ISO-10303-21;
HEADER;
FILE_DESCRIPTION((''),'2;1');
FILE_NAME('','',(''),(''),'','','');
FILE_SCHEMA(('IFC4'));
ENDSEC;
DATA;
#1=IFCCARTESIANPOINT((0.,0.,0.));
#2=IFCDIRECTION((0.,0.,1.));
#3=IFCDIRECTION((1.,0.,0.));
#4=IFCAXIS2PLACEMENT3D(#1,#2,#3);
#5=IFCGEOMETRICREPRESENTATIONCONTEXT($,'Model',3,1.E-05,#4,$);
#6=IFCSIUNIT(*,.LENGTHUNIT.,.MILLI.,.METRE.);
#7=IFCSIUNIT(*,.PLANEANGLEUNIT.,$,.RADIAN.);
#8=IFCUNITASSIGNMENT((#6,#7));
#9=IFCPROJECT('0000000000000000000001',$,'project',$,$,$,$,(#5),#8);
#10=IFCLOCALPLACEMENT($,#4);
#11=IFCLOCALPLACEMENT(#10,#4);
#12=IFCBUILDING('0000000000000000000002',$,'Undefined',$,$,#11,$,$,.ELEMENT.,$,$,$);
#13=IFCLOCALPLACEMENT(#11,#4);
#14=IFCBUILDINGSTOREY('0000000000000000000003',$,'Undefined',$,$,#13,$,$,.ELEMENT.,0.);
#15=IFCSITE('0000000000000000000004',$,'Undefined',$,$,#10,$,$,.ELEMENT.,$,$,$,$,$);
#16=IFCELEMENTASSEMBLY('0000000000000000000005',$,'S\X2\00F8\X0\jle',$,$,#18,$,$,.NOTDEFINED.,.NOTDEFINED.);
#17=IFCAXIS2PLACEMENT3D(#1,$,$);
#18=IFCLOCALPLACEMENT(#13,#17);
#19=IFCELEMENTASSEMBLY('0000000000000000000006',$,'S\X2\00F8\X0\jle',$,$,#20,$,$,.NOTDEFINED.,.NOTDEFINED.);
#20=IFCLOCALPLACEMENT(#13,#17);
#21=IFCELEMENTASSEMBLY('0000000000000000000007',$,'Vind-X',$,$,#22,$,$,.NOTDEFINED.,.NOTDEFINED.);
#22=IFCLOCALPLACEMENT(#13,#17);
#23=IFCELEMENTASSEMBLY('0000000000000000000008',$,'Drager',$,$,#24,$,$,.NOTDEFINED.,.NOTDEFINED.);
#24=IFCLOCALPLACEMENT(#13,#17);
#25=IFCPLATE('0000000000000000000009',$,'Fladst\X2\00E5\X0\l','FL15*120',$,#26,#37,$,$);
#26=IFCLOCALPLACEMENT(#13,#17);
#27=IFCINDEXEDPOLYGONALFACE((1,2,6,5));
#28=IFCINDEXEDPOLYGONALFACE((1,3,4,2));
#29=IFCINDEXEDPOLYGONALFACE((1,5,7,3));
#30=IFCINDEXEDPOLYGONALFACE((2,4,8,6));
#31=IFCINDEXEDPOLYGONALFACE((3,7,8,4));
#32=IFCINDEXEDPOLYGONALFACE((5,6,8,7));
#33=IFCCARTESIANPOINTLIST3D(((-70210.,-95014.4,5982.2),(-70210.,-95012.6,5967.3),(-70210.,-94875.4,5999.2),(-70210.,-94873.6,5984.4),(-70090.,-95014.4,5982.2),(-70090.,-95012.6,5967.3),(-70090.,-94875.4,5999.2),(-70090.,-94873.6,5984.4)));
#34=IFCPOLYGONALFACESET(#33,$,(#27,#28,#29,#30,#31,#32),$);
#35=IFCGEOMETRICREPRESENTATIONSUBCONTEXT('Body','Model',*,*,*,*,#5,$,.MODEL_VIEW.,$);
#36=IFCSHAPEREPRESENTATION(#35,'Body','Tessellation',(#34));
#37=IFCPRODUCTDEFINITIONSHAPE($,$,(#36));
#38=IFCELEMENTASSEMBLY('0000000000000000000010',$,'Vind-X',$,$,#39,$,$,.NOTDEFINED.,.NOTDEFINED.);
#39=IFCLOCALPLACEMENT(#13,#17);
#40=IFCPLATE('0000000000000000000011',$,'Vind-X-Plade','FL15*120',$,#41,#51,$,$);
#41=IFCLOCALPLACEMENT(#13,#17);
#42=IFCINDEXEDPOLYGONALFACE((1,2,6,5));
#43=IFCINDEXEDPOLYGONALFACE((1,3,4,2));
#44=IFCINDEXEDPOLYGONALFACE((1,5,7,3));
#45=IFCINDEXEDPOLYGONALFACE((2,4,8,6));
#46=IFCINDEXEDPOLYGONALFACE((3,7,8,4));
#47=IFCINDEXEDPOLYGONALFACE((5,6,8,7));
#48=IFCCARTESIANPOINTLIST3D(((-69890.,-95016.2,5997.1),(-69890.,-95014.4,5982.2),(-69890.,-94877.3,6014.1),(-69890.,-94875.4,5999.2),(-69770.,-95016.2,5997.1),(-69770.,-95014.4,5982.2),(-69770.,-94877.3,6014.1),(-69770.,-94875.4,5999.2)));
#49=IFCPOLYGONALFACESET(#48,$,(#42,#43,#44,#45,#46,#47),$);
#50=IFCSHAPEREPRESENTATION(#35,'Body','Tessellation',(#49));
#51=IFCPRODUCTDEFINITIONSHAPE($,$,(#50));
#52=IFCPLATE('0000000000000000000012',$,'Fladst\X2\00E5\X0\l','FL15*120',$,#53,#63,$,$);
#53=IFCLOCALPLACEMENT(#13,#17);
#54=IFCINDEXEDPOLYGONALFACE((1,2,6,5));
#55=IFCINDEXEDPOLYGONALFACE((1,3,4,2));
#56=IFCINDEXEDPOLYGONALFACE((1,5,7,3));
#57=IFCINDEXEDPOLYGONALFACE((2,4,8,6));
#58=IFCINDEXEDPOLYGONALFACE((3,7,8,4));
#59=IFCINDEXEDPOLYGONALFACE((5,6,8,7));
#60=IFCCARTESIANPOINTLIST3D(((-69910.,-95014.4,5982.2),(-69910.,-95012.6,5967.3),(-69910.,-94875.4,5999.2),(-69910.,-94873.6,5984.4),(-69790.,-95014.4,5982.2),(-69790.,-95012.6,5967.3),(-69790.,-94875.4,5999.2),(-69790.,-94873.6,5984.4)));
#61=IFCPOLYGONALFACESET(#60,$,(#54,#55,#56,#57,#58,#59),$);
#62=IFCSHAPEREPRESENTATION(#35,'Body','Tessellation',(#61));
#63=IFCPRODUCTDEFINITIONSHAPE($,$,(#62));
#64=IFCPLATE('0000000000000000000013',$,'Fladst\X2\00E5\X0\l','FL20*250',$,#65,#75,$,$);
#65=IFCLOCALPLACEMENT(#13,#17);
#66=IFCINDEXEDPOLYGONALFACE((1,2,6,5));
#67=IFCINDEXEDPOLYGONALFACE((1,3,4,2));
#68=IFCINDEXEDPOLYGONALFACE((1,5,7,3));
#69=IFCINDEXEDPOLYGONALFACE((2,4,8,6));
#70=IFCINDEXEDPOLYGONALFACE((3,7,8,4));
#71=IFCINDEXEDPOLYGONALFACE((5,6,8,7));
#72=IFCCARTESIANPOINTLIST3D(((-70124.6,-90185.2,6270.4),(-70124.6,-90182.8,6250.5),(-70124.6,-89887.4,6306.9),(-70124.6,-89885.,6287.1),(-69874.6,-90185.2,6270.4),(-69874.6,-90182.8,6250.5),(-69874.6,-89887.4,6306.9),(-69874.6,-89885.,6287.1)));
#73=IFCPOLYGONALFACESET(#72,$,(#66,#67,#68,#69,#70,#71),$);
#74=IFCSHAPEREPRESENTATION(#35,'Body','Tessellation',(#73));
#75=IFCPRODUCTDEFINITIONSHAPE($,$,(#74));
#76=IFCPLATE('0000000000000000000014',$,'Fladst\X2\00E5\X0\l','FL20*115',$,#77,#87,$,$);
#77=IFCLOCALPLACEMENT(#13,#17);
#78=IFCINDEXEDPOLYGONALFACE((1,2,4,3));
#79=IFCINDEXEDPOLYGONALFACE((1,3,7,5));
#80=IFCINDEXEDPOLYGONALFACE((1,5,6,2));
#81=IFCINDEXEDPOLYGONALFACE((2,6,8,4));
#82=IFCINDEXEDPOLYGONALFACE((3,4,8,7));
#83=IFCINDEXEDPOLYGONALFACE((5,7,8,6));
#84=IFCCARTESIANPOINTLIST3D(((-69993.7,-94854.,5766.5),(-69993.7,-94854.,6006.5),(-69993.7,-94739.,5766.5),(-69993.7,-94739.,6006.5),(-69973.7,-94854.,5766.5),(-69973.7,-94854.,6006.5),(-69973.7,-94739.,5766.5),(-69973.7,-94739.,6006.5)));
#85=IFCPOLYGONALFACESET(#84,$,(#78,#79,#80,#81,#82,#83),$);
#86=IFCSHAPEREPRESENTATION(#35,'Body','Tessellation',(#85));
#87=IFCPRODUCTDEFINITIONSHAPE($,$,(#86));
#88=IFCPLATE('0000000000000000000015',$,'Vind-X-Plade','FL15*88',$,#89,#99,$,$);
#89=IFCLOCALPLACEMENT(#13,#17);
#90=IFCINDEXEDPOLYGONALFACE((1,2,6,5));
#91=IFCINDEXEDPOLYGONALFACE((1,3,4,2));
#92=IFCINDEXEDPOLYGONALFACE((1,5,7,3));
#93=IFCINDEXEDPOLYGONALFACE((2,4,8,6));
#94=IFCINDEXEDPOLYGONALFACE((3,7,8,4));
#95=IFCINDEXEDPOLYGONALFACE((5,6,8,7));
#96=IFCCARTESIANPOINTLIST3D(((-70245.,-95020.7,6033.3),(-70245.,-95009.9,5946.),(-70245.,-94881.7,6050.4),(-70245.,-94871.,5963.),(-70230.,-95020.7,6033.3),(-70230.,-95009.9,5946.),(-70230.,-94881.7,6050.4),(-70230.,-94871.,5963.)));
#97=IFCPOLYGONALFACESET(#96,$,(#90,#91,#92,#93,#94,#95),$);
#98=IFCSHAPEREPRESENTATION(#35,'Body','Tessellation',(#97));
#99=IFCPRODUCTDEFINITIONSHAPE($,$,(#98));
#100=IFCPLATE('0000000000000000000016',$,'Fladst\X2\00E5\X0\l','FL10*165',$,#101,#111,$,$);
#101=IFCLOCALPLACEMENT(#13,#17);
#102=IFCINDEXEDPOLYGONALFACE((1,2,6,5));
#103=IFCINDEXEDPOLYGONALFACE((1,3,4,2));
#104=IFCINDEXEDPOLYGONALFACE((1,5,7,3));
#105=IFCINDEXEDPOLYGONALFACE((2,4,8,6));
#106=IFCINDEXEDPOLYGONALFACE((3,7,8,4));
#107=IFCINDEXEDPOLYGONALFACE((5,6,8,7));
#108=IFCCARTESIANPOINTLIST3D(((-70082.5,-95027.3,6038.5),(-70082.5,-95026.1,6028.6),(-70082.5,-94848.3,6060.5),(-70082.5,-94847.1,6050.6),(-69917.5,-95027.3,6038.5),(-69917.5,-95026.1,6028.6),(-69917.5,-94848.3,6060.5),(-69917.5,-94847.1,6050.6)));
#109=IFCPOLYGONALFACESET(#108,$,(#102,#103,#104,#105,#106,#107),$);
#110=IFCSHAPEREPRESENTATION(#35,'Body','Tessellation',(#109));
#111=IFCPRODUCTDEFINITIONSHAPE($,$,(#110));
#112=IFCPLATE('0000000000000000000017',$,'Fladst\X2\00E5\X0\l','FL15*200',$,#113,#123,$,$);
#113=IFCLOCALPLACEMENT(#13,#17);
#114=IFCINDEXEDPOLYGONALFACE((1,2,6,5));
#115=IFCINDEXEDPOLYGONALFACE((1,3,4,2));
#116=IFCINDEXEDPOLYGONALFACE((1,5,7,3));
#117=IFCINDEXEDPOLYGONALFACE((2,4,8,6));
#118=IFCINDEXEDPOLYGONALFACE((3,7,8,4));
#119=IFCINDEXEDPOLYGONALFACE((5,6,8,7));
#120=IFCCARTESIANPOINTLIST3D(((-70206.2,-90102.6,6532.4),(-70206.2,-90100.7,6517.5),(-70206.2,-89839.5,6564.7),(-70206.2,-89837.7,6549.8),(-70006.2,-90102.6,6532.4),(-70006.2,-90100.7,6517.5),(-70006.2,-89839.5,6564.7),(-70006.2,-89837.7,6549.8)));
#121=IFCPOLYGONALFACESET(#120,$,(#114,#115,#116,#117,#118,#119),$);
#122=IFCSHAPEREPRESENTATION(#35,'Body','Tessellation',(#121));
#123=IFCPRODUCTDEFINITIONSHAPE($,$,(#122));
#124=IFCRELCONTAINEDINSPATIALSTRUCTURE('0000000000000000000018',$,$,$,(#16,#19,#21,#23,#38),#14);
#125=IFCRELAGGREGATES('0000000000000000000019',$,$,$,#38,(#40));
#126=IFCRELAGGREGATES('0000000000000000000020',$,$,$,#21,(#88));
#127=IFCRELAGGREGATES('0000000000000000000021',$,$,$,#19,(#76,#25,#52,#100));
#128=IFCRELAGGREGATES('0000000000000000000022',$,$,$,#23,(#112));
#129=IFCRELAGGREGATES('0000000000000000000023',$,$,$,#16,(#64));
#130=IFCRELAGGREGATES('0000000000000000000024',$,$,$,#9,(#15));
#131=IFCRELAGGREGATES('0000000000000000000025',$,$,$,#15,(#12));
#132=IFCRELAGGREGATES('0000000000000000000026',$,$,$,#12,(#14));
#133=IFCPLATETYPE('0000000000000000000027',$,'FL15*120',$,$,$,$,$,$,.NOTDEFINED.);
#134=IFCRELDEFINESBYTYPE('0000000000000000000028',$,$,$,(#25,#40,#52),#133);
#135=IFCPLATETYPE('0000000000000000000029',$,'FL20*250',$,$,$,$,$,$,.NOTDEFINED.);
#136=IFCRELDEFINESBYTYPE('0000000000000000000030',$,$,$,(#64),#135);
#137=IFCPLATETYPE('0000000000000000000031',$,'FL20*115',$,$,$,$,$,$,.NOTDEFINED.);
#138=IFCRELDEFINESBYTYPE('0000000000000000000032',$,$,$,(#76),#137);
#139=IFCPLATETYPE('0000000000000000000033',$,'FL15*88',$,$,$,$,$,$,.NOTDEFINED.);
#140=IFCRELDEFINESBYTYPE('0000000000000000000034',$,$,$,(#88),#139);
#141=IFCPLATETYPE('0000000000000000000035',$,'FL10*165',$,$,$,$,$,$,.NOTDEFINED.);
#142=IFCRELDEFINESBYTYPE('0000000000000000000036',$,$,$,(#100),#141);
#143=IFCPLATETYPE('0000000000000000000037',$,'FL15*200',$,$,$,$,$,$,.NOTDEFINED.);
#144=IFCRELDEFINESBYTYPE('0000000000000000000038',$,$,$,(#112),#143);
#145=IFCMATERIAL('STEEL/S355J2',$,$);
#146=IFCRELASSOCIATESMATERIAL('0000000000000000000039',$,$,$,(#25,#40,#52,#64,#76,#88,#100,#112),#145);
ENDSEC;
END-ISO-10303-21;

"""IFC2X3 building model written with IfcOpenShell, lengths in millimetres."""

from ifc_helpers import new_model, si_unit, frame, origin_with_axes, place, context, subcontext, project, spatial, polyline, outline, extrude, material, type_object, element, aggregate, save


model = new_model("IFC2X3")

# Units and contexts
model_context = context("Model", 3, precision=1e-05, world=origin_with_axes())
body_context = subcontext(model_context, "Body", "Model", "MODEL_VIEW")
ifc_project = project(units=[si_unit("LENGTHUNIT", "METRE", prefix="MILLI"), si_unit("PLANEANGLEUNIT", "RADIAN")], contexts=[model_context])

# Site, building, storey
site_placement = place(None, origin_with_axes())
site = spatial("IfcSite", under=ifc_project, at=site_placement, Name="Undefined", CompositionType="ELEMENT")
building_placement = place(site_placement, origin_with_axes())
building = spatial("IfcBuilding", under=site, at=building_placement, Name="Undefined", CompositionType="ELEMENT")
storey_placement = place(building_placement, origin_with_axes())
storey = spatial("IfcBuildingStorey", under=building, at=storey_placement, Name="Undefined", CompositionType="ELEMENT", Elevation=0.0)

# Element assemblies
assembly_1_placement = place(storey_placement, origin_with_axes())
assembly_1 = element("IfcElementAssembly", 1, at=assembly_1_placement, inside=storey, Name="Søjle", AssemblyPlace="NOTDEFINED", PredefinedType="NOTDEFINED")
assembly_2_placement = place(storey_placement, origin_with_axes())
assembly_2 = element("IfcElementAssembly", 2, at=assembly_2_placement, inside=storey, Name="Søjle", AssemblyPlace="NOTDEFINED", PredefinedType="NOTDEFINED")

# Shared definitions
ifc_material_1 = material(Name="STEEL/S355J2")

# Element assembly
assembly_3_placement = place(storey_placement, origin_with_axes())
assembly_3 = element("IfcElementAssembly", 3, at=assembly_3_placement, inside=storey, Name="Vind-X", AssemblyPlace="NOTDEFINED", PredefinedType="NOTDEFINED")

# Element assembly
assembly_4_placement = place(storey_placement, origin_with_axes())
assembly_4 = element("IfcElementAssembly", 4, at=assembly_4_placement, inside=storey, Name="Drager", AssemblyPlace="NOTDEFINED", PredefinedType="NOTDEFINED")

# Shared definitions
plate_type_1 = type_object("IfcPlateType", Name="FL15*120", PredefinedType="NOTDEFINED")

# Plate
plate_1_placement = place(assembly_2_placement, frame((-70090.0, -95013.5, 5974.7), z_axis=(0.0, -0.121869, 0.992546), x_axis=(0.0, 0.992546, 0.121869)))
plate_1 = element("IfcPlate", 5, at=plate_1_placement, type_object=plate_type_1, material=ifc_material_1, Name="Fladstål", Description="FL15*120", context=body_context, shape_type="SweptSolid", body=[
    extrude(outline(polyline([(0.0, 0.0), (140.0, 0.0), (140.0, 120.0), (0.0, 120.0), (0.0, 0.0)])), frame((0.0, 0.0, -7.5), z_axis=(0.0, 0.0, 1.0), x_axis=(1.0, 0.0, 0.0)), (0.0, 0.0, 1.0), 15.0),
])

# Element assembly, plate
assembly_5_placement = place(storey_placement, origin_with_axes())
assembly_5 = element("IfcElementAssembly", 6, at=assembly_5_placement, inside=storey, Name="Vind-X", AssemblyPlace="NOTDEFINED", PredefinedType="NOTDEFINED")
plate_2_placement = place(assembly_5_placement, frame((-69890.0, -94945.8, 5998.2), z_axis=(0.0, 0.121869, -0.992546), x_axis=(1.0, 0.0, 0.0)))
plate_2 = element("IfcPlate", 7, at=plate_2_placement, type_object=plate_type_1, material=ifc_material_1, Name="Vind-X-Plade", Description="FL15*120", context=body_context, shape_type="SweptSolid", body=[
    extrude(outline(polyline([(0.0, -70.0), (0.0, 70.0), (120.0, 70.0), (120.0, -70.0), (0.0, -70.0)])), frame((0.0, 0.0, -7.5), z_axis=(0.0, 0.0, 1.0), x_axis=(1.0, 0.0, 0.0)), (0.0, 0.0, 1.0), 15.0),
])
aggregate(assembly_5, [plate_2])

# Plates
plate_3_placement = place(assembly_2_placement, frame((-69910.0, -94874.5, 5991.8), z_axis=(0.0, -0.121869, 0.992546), x_axis=(0.0, -0.992546, -0.121869)))
plate_3 = element("IfcPlate", 8, at=plate_3_placement, type_object=plate_type_1, material=ifc_material_1, Name="Fladstål", Description="FL15*120", context=body_context, shape_type="SweptSolid", body=[
    extrude(outline(polyline([(0.0, 0.0), (140.0, 0.0), (140.0, 120.0), (0.0, 120.0), (0.0, 0.0)])), frame((0.0, 0.0, -7.5), z_axis=(0.0, 0.0, 1.0), x_axis=(1.0, 0.0, 0.0)), (0.0, 0.0, 1.0), 15.0),
])
plate_type_2 = type_object("IfcPlateType", Name="FL20*250", PredefinedType="NOTDEFINED")
plate_4_placement = place(assembly_1_placement, frame((-69999.6, -90184.0, 6260.4), z_axis=(0.0, 0.121869, -0.992546), x_axis=(0.0, 0.992546, 0.121869)))
plate_4 = element("IfcPlate", 9, at=plate_4_placement, type_object=plate_type_2, material=ifc_material_1, Name="Fladstål", Description="FL20*250", context=body_context, shape_type="SweptSolid", body=[
    extrude(outline(polyline([(0.0, -125.0), (0.0, 125.0), (300.0, 125.0), (300.0, -125.0), (0.0, -125.0)])), frame((0.0, 0.0, -10.0), z_axis=(0.0, 0.0, 1.0), x_axis=(1.0, 0.0, 0.0)), (0.0, 0.0, 1.0), 20.0),
])
plate_type_3 = type_object("IfcPlateType", Name="FL20*115", PredefinedType="NOTDEFINED")
plate_5_placement = place(assembly_2_placement, frame((-69983.7, -94854.0, 6006.5), z_axis=(1.0, 0.0, 0.0), x_axis=(0.0, 0.0, -1.0)))
plate_5 = element("IfcPlate", 10, at=plate_5_placement, type_object=plate_type_3, material=ifc_material_1, Name="Fladstål", Description="FL20*115", context=body_context, shape_type="SweptSolid", body=[
    extrude(outline(polyline([(0.0, 0.0), (240.0, 0.0), (240.0, 115.0), (0.0, 115.0), (0.0, 0.0)])), frame((0.0, 0.0, -10.0), z_axis=(0.0, 0.0, 1.0), x_axis=(1.0, 0.0, 0.0)), (0.0, 0.0, 1.0), 20.0),
])
plate_type_4 = type_object("IfcPlateType", Name="FL15*88", PredefinedType="NOTDEFINED")
plate_6_placement = place(assembly_3_placement, frame((-70237.5, -95009.9, 5946.0), z_axis=(1.0, 0.0, 0.0), x_axis=(0.0, 0.992546, 0.121869)))
plate_6 = element("IfcPlate", 11, at=plate_6_placement, type_object=plate_type_4, material=ifc_material_1, Name="Vind-X-Plade", Description="FL15*88", context=body_context, shape_type="SweptSolid", body=[
    extrude(outline(polyline([(0.0, 0.0), (140.0, 0.0), (140.0, 88.0), (0.0, 88.0), (0.0, 0.0)])), frame((0.0, 0.0, -7.5), z_axis=(0.0, 0.0, 1.0), x_axis=(1.0, 0.0, 0.0)), (0.0, 0.0, 1.0), 15.0),
])
plate_type_5 = type_object("IfcPlateType", Name="FL10*165", PredefinedType="NOTDEFINED")
plate_7_placement = place(assembly_2_placement, frame((-70000.0, -95026.7, 6033.6), z_axis=(0.0, 0.121869, -0.992546), x_axis=(0.0, 0.992546, 0.121869)))
plate_7 = element("IfcPlate", 12, at=plate_7_placement, type_object=plate_type_5, material=ifc_material_1, Name="Fladstål", Description="FL10*165", context=body_context, shape_type="SweptSolid", body=[
    extrude(outline(polyline([(0.0, -82.5), (0.0, 82.5), (180.4, 82.5), (180.4, -82.5), (0.0, -82.5)])), frame((0.0, 0.0, -5.0), z_axis=(0.0, 0.0, 1.0), x_axis=(1.0, 0.0, 0.0)), (0.0, 0.0, 1.0), 10.0),
])
plate_type_6 = type_object("IfcPlateType", Name="FL15*200", PredefinedType="NOTDEFINED")
plate_8_placement = place(assembly_4_placement, frame((-70006.2, -90101.6, 6524.9), z_axis=(0.0, -0.121869, 0.992546), x_axis=(0.0, 0.992546, 0.121869)))
plate_8 = element("IfcPlate", 13, at=plate_8_placement, type_object=plate_type_6, material=ifc_material_1, Name="Fladstål", Description="FL15*200", context=body_context, shape_type="SweptSolid", body=[
    extrude(outline(polyline([(0.0, 0.0), (265.0, 0.0), (265.0, 200.0), (0.0, 200.0), (0.0, 0.0)])), frame((0.0, 0.0, -7.5), z_axis=(0.0, 0.0, 1.0), x_axis=(1.0, 0.0, 0.0)), (0.0, 0.0, 1.0), 15.0),
])

aggregate(assembly_3, [plate_6])
aggregate(assembly_2, [plate_5, plate_1, plate_3, plate_7])
aggregate(assembly_4, [plate_8])
aggregate(assembly_1, [plate_4])

save(model, "model.ifc")
